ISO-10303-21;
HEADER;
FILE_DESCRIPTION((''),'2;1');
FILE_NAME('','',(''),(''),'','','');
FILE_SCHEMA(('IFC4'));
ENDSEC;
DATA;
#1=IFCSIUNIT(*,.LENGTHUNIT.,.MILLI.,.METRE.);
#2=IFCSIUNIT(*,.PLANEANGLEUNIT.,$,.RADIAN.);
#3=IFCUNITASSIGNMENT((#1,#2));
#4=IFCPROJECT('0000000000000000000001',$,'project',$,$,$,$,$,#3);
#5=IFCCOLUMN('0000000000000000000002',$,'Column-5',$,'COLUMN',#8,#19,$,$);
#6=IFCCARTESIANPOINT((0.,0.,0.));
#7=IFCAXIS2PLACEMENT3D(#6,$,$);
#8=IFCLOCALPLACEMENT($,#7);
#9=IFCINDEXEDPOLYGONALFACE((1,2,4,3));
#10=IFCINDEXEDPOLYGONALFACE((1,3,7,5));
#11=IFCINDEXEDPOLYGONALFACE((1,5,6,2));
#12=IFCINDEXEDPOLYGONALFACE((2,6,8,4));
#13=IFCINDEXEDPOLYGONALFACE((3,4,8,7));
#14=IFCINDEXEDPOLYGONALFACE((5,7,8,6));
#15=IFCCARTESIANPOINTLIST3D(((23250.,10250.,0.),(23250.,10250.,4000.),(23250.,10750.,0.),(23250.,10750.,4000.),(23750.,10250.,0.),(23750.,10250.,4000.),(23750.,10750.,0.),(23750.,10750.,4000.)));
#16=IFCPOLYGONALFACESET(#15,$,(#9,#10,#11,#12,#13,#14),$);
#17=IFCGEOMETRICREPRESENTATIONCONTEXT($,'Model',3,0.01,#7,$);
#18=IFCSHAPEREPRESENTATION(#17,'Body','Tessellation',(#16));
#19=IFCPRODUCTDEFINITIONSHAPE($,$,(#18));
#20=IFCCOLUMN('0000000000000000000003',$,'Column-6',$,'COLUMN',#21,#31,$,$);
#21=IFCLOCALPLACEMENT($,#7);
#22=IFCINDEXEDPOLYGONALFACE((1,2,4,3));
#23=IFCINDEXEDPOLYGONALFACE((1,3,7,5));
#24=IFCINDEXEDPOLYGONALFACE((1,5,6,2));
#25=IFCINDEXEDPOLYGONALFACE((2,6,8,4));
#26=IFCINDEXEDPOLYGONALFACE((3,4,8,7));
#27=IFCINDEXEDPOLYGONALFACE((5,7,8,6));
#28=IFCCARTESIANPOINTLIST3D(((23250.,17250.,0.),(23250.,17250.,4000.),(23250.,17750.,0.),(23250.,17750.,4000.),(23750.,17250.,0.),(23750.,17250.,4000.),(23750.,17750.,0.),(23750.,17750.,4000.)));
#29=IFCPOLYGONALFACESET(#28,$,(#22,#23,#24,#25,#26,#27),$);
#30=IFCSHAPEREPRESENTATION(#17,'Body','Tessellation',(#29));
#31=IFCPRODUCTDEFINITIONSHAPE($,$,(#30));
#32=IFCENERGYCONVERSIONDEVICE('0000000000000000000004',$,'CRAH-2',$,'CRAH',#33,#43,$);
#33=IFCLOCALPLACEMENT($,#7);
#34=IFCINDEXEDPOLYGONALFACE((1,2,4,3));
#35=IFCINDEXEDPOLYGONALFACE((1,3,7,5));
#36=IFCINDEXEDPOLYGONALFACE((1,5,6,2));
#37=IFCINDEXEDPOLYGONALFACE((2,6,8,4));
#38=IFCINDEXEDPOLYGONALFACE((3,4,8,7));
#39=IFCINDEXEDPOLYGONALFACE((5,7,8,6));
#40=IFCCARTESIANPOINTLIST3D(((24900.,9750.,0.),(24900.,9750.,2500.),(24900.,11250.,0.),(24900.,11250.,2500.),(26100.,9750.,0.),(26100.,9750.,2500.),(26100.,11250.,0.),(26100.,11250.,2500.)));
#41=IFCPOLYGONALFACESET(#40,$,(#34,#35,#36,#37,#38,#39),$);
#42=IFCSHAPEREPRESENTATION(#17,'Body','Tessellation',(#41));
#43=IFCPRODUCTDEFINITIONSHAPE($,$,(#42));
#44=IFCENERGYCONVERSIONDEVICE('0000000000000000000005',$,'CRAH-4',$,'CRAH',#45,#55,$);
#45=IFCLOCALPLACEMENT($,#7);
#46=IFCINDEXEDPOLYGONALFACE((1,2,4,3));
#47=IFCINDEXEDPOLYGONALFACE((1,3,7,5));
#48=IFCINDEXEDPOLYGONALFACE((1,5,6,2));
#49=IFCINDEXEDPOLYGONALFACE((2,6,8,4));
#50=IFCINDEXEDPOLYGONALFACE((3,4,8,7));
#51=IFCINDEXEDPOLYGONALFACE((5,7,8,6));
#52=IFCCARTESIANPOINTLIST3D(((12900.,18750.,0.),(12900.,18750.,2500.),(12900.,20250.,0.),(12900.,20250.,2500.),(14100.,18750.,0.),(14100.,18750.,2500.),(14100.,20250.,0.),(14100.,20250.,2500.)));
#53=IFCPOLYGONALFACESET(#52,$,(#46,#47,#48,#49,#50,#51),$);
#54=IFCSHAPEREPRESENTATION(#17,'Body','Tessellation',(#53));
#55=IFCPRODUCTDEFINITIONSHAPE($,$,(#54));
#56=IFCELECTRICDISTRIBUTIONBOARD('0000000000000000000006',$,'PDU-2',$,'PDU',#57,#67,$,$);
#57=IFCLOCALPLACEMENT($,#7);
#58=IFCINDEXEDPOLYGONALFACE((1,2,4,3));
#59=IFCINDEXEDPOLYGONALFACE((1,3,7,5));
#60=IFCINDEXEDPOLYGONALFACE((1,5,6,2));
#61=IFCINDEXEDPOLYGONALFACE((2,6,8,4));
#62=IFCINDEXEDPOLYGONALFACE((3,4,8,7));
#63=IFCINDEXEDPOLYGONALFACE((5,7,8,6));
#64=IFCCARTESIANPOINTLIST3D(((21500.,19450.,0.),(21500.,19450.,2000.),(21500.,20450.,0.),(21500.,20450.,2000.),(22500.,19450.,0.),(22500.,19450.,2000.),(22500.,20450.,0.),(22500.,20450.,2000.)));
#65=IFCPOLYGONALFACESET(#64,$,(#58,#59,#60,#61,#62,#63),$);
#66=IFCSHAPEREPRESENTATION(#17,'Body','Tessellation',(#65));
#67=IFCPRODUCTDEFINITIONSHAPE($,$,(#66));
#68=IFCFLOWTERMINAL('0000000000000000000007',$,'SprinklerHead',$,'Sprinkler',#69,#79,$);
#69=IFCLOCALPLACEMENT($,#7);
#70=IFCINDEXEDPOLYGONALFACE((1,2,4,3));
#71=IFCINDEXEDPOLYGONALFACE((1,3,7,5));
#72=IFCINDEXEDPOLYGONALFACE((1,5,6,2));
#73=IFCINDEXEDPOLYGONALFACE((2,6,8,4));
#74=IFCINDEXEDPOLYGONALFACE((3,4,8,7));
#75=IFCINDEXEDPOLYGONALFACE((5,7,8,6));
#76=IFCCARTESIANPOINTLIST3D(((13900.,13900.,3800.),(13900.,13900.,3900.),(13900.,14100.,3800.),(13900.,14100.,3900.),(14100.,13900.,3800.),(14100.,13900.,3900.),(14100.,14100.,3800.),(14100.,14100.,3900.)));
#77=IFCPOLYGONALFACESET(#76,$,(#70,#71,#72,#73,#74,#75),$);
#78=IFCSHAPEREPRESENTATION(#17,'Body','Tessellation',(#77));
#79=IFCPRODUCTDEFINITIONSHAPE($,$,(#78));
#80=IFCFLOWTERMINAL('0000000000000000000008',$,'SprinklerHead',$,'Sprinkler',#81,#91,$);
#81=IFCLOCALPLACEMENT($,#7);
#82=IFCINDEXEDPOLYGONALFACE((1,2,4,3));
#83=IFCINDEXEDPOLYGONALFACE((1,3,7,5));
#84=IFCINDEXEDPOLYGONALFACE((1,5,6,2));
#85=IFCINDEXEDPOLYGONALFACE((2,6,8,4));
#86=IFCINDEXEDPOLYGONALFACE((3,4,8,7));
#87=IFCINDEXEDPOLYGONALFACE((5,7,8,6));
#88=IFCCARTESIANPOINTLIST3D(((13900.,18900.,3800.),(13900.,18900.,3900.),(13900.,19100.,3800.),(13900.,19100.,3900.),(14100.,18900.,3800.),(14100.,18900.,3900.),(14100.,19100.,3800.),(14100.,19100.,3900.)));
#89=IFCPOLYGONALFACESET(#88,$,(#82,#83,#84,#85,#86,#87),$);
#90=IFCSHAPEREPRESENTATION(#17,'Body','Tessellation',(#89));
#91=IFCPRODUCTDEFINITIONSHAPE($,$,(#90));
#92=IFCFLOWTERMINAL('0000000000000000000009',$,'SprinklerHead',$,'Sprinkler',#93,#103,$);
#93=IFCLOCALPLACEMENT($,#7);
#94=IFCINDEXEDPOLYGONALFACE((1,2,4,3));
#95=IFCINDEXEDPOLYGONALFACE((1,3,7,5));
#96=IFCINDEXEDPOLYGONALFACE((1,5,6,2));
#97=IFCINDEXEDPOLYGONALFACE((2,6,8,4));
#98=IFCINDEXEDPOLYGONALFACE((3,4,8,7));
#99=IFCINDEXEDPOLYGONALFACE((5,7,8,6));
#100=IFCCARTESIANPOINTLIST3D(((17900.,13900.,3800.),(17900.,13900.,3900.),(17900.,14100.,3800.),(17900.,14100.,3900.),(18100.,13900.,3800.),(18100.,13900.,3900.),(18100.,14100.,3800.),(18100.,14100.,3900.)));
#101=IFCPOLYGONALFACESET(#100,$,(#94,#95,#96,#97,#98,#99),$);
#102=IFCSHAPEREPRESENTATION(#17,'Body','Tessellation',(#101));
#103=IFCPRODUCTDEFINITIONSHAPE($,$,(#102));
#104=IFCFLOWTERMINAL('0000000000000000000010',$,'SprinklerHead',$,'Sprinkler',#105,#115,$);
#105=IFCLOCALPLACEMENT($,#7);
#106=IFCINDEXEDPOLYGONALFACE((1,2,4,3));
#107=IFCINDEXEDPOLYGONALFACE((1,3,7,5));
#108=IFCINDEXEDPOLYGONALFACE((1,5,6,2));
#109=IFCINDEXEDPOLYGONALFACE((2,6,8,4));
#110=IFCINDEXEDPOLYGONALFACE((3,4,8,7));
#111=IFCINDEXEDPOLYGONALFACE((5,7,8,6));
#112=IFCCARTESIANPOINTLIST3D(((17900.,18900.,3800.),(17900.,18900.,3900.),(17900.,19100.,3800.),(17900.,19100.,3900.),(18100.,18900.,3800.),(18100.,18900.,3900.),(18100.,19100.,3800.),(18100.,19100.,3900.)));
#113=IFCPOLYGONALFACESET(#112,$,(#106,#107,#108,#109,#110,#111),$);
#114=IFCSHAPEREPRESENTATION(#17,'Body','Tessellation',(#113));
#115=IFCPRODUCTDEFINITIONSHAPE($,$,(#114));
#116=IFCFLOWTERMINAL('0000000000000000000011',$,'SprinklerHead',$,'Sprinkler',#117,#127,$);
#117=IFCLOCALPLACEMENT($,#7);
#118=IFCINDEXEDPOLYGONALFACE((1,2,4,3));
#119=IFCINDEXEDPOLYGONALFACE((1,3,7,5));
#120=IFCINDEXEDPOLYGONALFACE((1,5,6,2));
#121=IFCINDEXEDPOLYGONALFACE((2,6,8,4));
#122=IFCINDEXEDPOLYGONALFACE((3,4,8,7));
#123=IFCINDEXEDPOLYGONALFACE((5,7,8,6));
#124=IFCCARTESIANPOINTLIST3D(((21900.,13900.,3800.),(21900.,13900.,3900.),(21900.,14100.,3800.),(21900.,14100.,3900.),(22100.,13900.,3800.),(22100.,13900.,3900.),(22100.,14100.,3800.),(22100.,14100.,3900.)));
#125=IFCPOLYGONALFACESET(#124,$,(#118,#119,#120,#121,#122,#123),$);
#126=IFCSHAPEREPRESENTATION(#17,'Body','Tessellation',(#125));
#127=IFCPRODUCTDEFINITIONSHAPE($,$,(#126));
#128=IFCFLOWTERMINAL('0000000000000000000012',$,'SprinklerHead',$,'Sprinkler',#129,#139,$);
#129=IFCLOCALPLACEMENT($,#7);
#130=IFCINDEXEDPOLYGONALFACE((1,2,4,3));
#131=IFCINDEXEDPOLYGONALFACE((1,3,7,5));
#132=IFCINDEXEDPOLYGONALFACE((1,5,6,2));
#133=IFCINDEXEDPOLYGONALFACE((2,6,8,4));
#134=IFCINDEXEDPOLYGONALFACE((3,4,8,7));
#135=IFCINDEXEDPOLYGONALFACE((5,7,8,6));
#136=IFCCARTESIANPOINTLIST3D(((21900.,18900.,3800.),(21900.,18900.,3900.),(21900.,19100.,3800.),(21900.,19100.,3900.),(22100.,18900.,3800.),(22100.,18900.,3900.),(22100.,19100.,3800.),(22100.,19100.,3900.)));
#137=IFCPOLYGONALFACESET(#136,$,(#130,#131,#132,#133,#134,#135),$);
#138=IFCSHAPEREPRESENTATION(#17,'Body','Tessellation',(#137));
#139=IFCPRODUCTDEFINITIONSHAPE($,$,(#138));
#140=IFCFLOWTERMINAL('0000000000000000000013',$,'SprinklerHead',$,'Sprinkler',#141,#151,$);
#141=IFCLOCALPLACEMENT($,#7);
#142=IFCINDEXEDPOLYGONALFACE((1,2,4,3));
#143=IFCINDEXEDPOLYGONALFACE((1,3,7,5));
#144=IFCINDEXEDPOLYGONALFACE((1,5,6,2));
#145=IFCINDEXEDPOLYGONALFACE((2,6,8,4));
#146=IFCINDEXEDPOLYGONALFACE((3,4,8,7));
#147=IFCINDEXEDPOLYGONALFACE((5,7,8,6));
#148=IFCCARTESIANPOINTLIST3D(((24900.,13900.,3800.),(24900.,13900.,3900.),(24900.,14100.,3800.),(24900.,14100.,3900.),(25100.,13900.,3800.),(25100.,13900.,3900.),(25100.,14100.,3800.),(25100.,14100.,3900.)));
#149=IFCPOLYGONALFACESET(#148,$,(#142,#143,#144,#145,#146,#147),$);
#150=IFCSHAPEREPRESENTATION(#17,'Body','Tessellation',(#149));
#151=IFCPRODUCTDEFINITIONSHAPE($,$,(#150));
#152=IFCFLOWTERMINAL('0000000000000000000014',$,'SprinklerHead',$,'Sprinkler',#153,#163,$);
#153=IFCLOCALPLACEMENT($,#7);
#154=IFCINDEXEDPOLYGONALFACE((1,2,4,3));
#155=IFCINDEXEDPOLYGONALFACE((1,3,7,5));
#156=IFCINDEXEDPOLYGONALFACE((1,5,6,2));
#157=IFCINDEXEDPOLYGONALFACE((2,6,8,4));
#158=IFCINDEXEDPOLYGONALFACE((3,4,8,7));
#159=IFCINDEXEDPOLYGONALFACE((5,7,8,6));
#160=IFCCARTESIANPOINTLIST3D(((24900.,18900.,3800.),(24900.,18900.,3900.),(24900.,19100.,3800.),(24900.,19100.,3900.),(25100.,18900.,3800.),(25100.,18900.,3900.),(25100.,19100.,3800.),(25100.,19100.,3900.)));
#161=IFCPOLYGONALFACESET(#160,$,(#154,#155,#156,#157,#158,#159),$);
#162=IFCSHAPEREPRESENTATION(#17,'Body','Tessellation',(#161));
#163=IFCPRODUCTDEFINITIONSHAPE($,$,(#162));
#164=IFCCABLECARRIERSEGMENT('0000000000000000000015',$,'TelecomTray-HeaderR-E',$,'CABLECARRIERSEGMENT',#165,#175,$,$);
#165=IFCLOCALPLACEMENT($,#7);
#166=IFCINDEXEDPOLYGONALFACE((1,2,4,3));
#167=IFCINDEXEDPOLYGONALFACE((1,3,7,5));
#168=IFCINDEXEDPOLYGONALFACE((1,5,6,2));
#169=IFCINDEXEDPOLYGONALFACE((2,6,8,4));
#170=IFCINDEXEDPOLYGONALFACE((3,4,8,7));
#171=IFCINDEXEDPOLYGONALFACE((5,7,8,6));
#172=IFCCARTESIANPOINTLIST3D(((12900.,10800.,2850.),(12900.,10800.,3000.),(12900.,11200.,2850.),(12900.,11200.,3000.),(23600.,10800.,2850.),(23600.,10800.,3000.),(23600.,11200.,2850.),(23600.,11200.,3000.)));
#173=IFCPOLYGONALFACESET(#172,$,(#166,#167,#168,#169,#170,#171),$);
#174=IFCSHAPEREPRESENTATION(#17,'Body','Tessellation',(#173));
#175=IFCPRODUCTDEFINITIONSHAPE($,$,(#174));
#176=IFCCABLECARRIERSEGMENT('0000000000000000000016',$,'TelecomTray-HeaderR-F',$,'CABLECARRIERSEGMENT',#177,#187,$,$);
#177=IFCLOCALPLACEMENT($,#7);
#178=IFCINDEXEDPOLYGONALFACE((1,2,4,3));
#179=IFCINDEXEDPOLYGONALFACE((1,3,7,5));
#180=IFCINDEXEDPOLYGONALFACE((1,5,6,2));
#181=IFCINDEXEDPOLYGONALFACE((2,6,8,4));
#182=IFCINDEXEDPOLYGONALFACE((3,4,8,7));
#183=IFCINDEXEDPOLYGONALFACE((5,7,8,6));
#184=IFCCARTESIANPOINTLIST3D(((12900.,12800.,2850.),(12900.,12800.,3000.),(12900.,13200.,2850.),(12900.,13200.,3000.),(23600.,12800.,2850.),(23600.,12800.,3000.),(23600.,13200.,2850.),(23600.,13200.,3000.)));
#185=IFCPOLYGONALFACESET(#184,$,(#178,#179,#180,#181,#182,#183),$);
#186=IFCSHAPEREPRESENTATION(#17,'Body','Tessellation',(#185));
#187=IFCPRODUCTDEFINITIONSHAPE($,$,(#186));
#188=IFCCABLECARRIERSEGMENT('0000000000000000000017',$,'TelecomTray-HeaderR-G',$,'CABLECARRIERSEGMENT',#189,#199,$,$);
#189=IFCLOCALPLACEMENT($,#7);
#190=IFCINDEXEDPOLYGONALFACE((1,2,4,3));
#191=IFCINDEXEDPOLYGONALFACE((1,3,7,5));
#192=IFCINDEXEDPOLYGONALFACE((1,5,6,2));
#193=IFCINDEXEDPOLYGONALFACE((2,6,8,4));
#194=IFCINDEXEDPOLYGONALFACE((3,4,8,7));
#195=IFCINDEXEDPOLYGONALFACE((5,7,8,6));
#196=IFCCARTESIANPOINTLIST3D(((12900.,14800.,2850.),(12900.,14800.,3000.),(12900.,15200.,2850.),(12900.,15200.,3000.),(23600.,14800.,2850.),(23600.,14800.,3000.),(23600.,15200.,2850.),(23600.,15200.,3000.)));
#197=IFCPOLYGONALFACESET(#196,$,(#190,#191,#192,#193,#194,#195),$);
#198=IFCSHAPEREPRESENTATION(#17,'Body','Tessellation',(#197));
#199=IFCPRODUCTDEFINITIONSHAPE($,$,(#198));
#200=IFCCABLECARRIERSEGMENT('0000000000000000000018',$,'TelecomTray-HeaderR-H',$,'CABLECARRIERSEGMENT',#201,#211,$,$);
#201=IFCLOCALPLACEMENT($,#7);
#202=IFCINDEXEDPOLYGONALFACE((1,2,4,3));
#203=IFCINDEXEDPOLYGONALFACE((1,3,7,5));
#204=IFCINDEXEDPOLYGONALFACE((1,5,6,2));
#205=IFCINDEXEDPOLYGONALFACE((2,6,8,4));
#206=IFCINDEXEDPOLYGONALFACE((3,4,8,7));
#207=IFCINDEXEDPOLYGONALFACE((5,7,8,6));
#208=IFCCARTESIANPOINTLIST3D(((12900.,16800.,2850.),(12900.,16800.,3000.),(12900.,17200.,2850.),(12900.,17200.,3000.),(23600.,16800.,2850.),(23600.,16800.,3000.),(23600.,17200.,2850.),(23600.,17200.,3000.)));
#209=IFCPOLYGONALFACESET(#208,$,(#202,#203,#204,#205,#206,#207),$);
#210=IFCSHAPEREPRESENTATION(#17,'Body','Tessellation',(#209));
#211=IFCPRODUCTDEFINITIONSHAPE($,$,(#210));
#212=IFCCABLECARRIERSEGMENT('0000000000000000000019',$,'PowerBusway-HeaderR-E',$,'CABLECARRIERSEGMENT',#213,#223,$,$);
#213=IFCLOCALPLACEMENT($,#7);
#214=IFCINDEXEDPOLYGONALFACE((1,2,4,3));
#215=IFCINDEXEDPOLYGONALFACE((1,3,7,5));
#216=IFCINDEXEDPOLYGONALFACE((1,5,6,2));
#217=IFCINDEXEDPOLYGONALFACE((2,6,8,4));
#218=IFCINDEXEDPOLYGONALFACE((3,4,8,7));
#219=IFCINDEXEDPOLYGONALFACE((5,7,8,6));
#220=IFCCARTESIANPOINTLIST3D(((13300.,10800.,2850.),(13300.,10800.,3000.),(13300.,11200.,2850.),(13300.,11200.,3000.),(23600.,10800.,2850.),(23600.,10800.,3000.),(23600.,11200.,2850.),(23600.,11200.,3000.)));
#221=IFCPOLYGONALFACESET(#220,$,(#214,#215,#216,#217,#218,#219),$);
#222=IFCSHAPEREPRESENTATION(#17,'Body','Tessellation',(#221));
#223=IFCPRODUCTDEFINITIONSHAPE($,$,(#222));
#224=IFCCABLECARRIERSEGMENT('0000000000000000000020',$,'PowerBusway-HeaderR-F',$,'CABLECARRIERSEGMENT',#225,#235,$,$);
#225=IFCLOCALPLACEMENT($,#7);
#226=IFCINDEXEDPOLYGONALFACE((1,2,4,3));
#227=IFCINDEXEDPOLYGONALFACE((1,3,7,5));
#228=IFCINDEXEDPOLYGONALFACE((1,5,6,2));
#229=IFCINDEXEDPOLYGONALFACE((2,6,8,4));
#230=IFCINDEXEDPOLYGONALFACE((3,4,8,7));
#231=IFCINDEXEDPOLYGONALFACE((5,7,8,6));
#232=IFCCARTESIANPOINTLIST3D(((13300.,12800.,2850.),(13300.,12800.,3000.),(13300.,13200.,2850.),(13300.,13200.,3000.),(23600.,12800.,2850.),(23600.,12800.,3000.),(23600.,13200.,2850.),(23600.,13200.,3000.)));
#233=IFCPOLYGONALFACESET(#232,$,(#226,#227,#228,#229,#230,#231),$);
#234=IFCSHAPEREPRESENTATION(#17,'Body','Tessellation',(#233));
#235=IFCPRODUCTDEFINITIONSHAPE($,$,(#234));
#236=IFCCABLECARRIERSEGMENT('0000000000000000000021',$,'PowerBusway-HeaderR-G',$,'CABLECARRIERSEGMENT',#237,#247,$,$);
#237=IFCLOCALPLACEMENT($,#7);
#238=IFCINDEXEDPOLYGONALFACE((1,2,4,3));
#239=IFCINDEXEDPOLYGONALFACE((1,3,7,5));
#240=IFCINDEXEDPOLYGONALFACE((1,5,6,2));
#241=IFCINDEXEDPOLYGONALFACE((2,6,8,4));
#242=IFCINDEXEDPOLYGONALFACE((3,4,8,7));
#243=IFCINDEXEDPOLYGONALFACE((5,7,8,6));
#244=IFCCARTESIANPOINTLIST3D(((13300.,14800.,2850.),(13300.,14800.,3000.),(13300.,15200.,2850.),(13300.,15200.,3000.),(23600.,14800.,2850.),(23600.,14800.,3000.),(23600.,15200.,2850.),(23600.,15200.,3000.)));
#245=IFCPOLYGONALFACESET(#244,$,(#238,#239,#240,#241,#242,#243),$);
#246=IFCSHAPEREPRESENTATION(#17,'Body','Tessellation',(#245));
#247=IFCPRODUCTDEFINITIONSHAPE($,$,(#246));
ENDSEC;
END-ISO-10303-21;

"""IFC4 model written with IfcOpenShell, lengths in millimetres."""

from ifc_helpers import new_model, si_unit, frame, origin, place, context, project, polyline, outline, extrude, element, save


model = new_model("IFC4")

# Units and contexts
model_context = context("Model", 3, precision=0.01, world=origin())
ifc_project = project(units=[si_unit("LENGTHUNIT", "METRE", prefix="MILLI"), si_unit("PLANEANGLEUNIT", "RADIAN")])

# Columns
for number, where, name in (
    (1, (23500.0, 10500.0, 0.0), "Column-5"),
    (2, (23500.0, 17500.0, 0.0), "Column-6"),
):
    element("IfcColumn", number, at=place(None, frame(where)), Name=name, ObjectType="COLUMN", context=model_context, shape_type="SweptSolid", body=[
        extrude(outline(polyline([(-250.0, -250.0), (250.0, -250.0), (250.0, 250.0), (-250.0, 250.0), (-250.0, -250.0)])), origin(), (0.0, 0.0, 1.0), 4000.0),
    ])

# Energy conversion devices
for number, where, name in (
    (3, (25500.0, 10500.0, 0.0), "CRAH-2"),
    (4, (13500.0, 19500.0, 0.0), "CRAH-4"),
):
    element("IfcEnergyConversionDevice", number, at=place(None, frame(where)), Name=name, ObjectType="CRAH", context=model_context, shape_type="SweptSolid", body=[
        extrude(outline(polyline([(-600.0, -750.0), (600.0, -750.0), (600.0, 750.0), (-600.0, 750.0), (-600.0, -750.0)])), origin(), (0.0, 0.0, 1.0), 2500.0),
    ])

# Electric distribution board
electric_distribution_board_placement = place(None, frame((22000.0, 19950.0, 0.0)))
element("IfcElectricDistributionBoard", 5, at=electric_distribution_board_placement, Name="PDU-2", ObjectType="PDU", context=model_context, shape_type="SweptSolid", body=[
    extrude(outline(polyline([(-500.0, -500.0), (500.0, -500.0), (500.0, 500.0), (-500.0, 500.0), (-500.0, -500.0)])), origin(), (0.0, 0.0, 1.0), 2000.0),
])

# Flow terminals
for number, where, name in (
    (6, (14000.0, 14000.0, 3800.0), "SprinklerHead"),
    (7, (14000.0, 19000.0, 3800.0), "SprinklerHead"),
    (8, (18000.0, 14000.0, 3800.0), "SprinklerHead"),
    (9, (18000.0, 19000.0, 3800.0), "SprinklerHead"),
    (10, (22000.0, 14000.0, 3800.0), "SprinklerHead"),
    (11, (22000.0, 19000.0, 3800.0), "SprinklerHead"),
    (12, (25000.0, 14000.0, 3800.0), "SprinklerHead"),
    (13, (25000.0, 19000.0, 3800.0), "SprinklerHead"),
):
    element("IfcFlowTerminal", number, at=place(None, frame(where)), Name=name, ObjectType="Sprinkler", context=model_context, shape_type="SweptSolid", body=[
        extrude(outline(polyline([(-100.0, -100.0), (100.0, -100.0), (100.0, 100.0), (-100.0, 100.0), (-100.0, -100.0)])), origin(), (0.0, 0.0, 1.0), 100.0),
    ])

# Cable carrier segments
for number, where, name in (
    (14, (18250.0, 11000.0, 2850.0), "TelecomTray-HeaderR-E"),
    (15, (18250.0, 13000.0, 2850.0), "TelecomTray-HeaderR-F"),
    (16, (18250.0, 15000.0, 2850.0), "TelecomTray-HeaderR-G"),
    (17, (18250.0, 17000.0, 2850.0), "TelecomTray-HeaderR-H"),
):
    element("IfcCableCarrierSegment", number, at=place(None, frame(where)), Name=name, ObjectType="CABLECARRIERSEGMENT", context=model_context, shape_type="SweptSolid", body=[
        extrude(outline(polyline([(-5350.0, -200.0), (5350.0, -200.0), (5350.0, 200.0), (-5350.0, 200.0), (-5350.0, -200.0)])), origin(), (0.0, 0.0, 1.0), 150.0),
    ])
for number, where, name in (
    (18, (18450.0, 11000.0, 2850.0), "PowerBusway-HeaderR-E"),
    (19, (18450.0, 13000.0, 2850.0), "PowerBusway-HeaderR-F"),
    (20, (18450.0, 15000.0, 2850.0), "PowerBusway-HeaderR-G"),
):
    element("IfcCableCarrierSegment", number, at=place(None, frame(where)), Name=name, ObjectType="CABLECARRIERSEGMENT", context=model_context, shape_type="SweptSolid", body=[
        extrude(outline(polyline([(-5150.0, -200.0), (5150.0, -200.0), (5150.0, 200.0), (-5150.0, 200.0), (-5150.0, -200.0)])), origin(), (0.0, 0.0, 1.0), 150.0),
    ])

save(model, "model.ifc")
